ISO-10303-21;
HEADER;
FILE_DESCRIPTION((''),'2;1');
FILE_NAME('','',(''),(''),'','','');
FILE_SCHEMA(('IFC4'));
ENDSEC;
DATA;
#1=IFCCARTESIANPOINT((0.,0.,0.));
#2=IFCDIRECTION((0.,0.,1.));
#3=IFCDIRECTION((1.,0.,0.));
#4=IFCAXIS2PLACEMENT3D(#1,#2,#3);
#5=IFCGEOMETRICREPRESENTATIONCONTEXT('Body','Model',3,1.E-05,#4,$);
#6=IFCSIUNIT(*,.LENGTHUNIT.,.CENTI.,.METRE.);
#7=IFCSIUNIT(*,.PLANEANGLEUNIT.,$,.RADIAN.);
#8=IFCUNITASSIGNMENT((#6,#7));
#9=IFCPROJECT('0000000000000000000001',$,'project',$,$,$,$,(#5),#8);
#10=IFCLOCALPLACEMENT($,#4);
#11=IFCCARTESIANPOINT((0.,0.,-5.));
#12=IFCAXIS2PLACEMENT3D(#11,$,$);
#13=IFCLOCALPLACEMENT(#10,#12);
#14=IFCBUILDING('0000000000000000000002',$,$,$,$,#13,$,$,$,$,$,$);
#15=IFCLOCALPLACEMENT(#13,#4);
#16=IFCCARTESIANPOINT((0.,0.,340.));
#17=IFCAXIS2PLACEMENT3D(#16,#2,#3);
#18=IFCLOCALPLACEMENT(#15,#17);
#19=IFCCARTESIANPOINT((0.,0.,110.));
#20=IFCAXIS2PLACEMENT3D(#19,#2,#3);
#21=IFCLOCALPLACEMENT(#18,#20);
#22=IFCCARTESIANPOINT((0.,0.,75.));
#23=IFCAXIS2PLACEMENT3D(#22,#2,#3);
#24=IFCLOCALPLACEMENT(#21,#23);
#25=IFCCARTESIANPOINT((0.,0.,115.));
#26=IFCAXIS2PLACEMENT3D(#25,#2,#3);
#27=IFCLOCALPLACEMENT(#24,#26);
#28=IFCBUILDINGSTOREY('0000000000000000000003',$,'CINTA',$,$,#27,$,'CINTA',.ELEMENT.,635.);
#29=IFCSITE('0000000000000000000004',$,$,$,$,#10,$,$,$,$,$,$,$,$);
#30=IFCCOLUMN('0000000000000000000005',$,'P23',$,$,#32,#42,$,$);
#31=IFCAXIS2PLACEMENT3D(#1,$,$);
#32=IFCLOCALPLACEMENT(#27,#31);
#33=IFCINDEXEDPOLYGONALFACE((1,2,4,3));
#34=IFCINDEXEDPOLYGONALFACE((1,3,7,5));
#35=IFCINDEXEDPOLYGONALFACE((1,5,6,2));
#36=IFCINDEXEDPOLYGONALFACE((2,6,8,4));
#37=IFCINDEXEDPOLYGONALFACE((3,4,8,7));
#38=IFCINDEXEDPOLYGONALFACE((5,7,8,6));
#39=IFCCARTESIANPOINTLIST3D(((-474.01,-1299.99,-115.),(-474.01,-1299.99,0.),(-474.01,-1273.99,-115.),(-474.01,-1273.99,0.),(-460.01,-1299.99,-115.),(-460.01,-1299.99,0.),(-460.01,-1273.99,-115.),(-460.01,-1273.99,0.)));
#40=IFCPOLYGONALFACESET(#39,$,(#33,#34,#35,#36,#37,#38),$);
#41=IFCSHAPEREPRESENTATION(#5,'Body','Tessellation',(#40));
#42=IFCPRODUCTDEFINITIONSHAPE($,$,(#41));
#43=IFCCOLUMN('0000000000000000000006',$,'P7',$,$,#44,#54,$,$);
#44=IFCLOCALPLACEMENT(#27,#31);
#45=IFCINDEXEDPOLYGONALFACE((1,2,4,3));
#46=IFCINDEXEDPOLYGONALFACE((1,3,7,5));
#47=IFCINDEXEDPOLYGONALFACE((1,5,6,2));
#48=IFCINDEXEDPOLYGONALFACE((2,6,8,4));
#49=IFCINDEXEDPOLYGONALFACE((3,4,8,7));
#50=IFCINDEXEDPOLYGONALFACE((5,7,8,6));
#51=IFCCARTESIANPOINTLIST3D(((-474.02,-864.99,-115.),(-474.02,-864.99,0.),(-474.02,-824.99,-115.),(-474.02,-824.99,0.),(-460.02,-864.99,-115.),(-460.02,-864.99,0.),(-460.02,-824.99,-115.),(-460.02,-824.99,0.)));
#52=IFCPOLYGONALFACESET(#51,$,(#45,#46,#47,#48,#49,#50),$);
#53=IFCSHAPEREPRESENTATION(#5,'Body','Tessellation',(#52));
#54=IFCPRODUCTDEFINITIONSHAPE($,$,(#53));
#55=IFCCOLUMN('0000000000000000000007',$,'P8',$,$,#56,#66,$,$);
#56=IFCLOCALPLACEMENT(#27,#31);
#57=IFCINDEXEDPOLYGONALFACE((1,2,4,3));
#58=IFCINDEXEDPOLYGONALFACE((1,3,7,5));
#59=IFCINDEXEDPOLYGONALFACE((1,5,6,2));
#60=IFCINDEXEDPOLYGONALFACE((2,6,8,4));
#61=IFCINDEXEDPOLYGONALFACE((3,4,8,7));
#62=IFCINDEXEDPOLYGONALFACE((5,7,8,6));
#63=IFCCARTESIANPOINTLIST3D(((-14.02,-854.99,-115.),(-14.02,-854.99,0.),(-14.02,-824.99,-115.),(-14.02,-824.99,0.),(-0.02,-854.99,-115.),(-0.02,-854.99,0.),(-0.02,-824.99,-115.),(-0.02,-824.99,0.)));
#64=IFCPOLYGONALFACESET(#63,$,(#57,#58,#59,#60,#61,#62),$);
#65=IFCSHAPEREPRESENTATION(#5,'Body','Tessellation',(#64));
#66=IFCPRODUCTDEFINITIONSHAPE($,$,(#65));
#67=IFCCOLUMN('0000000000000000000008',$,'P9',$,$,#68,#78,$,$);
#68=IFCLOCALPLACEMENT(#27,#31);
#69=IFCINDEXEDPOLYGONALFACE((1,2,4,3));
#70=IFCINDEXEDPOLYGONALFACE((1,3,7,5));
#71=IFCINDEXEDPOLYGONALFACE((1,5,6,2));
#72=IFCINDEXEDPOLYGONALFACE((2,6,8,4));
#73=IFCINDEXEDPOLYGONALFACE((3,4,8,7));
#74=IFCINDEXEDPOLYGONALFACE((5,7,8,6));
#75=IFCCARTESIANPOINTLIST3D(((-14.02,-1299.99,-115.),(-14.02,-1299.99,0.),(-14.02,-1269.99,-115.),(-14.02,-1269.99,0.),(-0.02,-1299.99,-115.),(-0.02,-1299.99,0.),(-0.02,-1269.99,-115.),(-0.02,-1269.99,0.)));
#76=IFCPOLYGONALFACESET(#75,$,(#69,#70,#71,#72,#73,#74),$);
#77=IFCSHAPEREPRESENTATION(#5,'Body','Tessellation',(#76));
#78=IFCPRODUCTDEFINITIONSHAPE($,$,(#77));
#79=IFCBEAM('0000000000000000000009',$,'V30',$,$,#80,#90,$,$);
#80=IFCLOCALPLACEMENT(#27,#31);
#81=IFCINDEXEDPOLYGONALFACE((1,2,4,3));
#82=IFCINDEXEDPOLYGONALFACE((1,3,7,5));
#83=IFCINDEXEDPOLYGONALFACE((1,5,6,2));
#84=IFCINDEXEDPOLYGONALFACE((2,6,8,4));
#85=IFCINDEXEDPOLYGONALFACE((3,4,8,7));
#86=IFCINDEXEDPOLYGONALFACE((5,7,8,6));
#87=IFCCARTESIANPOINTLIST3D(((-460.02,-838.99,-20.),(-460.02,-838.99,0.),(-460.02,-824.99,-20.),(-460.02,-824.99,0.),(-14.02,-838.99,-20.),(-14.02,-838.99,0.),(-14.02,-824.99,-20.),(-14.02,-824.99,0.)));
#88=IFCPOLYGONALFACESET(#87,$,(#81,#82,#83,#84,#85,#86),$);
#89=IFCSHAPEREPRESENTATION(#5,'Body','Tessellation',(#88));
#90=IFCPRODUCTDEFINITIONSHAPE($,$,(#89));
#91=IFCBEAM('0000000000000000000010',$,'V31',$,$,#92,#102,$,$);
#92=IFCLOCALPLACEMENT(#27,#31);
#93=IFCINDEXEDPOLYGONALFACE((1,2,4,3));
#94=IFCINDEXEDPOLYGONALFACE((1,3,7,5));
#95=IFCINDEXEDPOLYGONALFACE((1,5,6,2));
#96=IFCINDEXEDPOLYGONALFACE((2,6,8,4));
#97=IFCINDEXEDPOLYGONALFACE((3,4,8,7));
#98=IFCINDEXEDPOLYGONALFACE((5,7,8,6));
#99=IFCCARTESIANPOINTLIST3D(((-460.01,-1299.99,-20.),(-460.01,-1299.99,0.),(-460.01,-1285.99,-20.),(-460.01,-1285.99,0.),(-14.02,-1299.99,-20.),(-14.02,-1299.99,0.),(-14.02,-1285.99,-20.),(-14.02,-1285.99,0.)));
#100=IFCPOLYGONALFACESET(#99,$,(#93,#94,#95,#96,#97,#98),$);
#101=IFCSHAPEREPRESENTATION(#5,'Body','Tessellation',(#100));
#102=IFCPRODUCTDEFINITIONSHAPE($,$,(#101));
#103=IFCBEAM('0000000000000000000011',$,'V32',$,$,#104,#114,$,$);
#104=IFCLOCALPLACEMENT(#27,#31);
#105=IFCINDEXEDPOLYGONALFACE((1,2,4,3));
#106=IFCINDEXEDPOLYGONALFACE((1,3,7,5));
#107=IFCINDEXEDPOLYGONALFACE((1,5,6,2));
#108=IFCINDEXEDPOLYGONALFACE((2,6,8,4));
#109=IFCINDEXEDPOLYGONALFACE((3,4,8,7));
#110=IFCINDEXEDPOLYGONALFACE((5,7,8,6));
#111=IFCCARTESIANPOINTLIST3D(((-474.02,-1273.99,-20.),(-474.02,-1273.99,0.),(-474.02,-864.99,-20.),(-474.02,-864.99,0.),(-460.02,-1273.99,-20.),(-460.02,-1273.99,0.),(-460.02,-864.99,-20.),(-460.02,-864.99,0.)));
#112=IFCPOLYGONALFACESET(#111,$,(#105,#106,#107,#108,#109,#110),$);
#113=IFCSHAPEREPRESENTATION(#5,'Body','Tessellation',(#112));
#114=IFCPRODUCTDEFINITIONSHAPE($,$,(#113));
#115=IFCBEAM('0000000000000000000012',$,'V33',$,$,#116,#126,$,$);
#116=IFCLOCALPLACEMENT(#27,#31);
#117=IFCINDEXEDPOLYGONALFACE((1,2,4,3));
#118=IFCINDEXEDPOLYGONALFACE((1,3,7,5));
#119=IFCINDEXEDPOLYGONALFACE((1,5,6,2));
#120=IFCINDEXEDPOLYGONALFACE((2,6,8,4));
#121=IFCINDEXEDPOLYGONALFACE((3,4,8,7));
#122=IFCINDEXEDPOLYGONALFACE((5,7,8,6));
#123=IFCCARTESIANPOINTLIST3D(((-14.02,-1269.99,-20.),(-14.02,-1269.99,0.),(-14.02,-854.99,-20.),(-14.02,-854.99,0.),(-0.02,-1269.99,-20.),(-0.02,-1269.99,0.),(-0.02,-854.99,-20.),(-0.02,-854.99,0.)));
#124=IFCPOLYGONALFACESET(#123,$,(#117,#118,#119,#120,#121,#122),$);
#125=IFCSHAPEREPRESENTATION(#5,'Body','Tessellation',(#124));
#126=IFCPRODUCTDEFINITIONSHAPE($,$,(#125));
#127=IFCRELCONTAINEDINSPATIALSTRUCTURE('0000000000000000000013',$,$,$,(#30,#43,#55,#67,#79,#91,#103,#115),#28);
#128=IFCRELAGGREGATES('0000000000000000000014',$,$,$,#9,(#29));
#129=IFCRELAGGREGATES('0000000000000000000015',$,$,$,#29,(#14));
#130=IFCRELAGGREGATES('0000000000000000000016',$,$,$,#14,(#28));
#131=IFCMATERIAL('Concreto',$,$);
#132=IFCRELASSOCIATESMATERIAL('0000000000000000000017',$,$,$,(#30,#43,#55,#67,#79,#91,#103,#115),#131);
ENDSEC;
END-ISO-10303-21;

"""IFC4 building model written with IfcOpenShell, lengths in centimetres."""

from ifc_helpers import new_model, si_unit, frame, origin_with_axes, origin_2d_with_axis, place, context, project, spatial, rectangle, extrude, material, element, save


model = new_model("IFC4")

# Units and contexts
model_context = context("Model", 3, precision=1e-05, world=origin_with_axes(), identifier="Body")
ifc_project = project(units=[si_unit("LENGTHUNIT", "METRE", prefix="CENTI"), si_unit("PLANEANGLEUNIT", "RADIAN")], contexts=[model_context])

# Site, building, storey
site_placement = place(None, origin_with_axes())
site = spatial("IfcSite", under=ifc_project, at=site_placement)
building_placement = place(site_placement, frame((0.0, 0.0, -5.0)))
building = spatial("IfcBuilding", under=site, at=building_placement)
placement_1 = place(building_placement, origin_with_axes())
placement_2 = place(placement_1, frame((0.0, 0.0, 340.0), z_axis=(0.0, 0.0, 1.0), x_axis=(1.0, 0.0, 0.0)))
placement_3 = place(placement_2, frame((0.0, 0.0, 110.0), z_axis=(0.0, 0.0, 1.0), x_axis=(1.0, 0.0, 0.0)))
placement_4 = place(placement_3, frame((0.0, 0.0, 75.0), z_axis=(0.0, 0.0, 1.0), x_axis=(1.0, 0.0, 0.0)))
storey_placement = place(placement_4, frame((0.0, 0.0, 115.0), z_axis=(0.0, 0.0, 1.0), x_axis=(1.0, 0.0, 0.0)))
storey = spatial("IfcBuildingStorey", under=building, at=storey_placement, Name="CINTA", LongName="CINTA", CompositionType="ELEMENT", Elevation=635.0)

# Columns
ifc_material = material(Name="Concreto")
column_1_placement = place(storey_placement, frame((-467.01, -1286.99, 0.0), z_axis=(0.0, 0.0, 1.0), x_axis=(1.0, 0.0, 0.0)))
element("IfcColumn", 1, at=column_1_placement, inside=storey, material=ifc_material, Name="P23", context=model_context, shape_type="SolidModel", body=[
    extrude(rectangle(XDim=14.0, YDim=26.0, at=origin_2d_with_axis()), origin_with_axes(), (0.0, 0.0, -1.0), 115.0),
])
column_2_placement = place(storey_placement, frame((-467.02, -844.99, 0.0), z_axis=(0.0, 0.0, 1.0), x_axis=(1.0, 0.0, 0.0)))
element("IfcColumn", 2, at=column_2_placement, inside=storey, material=ifc_material, Name="P7", context=model_context, shape_type="SolidModel", body=[
    extrude(rectangle(XDim=14.0, YDim=40.0, at=origin_2d_with_axis()), origin_with_axes(), (0.0, 0.0, -1.0), 115.0),
])
for number, where, z_axis, x_axis, name in (
    (3, (-7.02, -839.99, 0.0), (0.0, 0.0, 1.0), (1.0, 0.0, 0.0), "P8"),
    (4, (-7.02, -1284.99, 0.0), (0.0, 0.0, 1.0), (1.0, 0.0, 0.0), "P9"),
):
    element("IfcColumn", number, at=place(storey_placement, frame(where, z_axis=z_axis, x_axis=x_axis)), inside=storey, material=ifc_material, Name=name, context=model_context, shape_type="SolidModel", body=[
        extrude(rectangle(XDim=14.0, YDim=30.0, at=origin_2d_with_axis()), origin_with_axes(), (0.0, 0.0, -1.0), 115.0),
    ])

# Beams
beam_1_placement = place(storey_placement, frame((-237.02, -831.99, 0.0), z_axis=(0.0, 0.0, 1.0), x_axis=(1.0, 0.0, 0.0)))
element("IfcBeam", 5, at=beam_1_placement, inside=storey, material=ifc_material, Name="V30", context=model_context, shape_type="SolidModel", body=[
    extrude(rectangle(XDim=14.0, YDim=20.0, at=origin_2d_with_axis()), frame((-223.0, 0.0, -10.0), z_axis=(1.0, 0.0, 0.0), x_axis=(0.0, -1.0, 0.0)), (0.0, 0.0, 1.0), 446.0),
])
beam_2_placement = place(storey_placement, frame((-237.01, -1292.99, 0.0), z_axis=(0.0, 0.0, 1.0), x_axis=(1.0, 0.0, 0.0)))
element("IfcBeam", 6, at=beam_2_placement, inside=storey, material=ifc_material, Name="V31", context=model_context, shape_type="SolidModel", body=[
    extrude(rectangle(XDim=14.0, YDim=20.0, at=origin_2d_with_axis()), frame((-223.0, 0.0, -10.0), z_axis=(1.0, 0.0, 0.0), x_axis=(0.0, -1.0, 0.0)), (0.0, 0.0, 1.0), 445.99),
])
beam_3_placement = place(storey_placement, frame((-467.02, -1069.49, 0.0), z_axis=(0.0, 0.0, 1.0), x_axis=(1.0, 0.0, 0.0)))
element("IfcBeam", 7, at=beam_3_placement, inside=storey, material=ifc_material, Name="V32", context=model_context, shape_type="SolidModel", body=[
    extrude(rectangle(XDim=14.0, YDim=20.0, at=origin_2d_with_axis()), frame((0.0, -204.5, -10.0), z_axis=(0.0, 1.0, 0.0), x_axis=(1.0, 0.0, 0.0)), (0.0, 0.0, 1.0), 409.0),
])
beam_4_placement = place(storey_placement, frame((-7.02, -1062.49, 0.0), z_axis=(0.0, 0.0, 1.0), x_axis=(1.0, 0.0, 0.0)))
element("IfcBeam", 8, at=beam_4_placement, inside=storey, material=ifc_material, Name="V33", context=model_context, shape_type="SolidModel", body=[
    extrude(rectangle(XDim=14.0, YDim=20.0, at=origin_2d_with_axis()), frame((0.0, -207.5, -10.0), z_axis=(0.0, 1.0, 0.0), x_axis=(1.0, 0.0, 0.0)), (0.0, 0.0, 1.0), 415.0),
])

save(model, "model.ifc")
